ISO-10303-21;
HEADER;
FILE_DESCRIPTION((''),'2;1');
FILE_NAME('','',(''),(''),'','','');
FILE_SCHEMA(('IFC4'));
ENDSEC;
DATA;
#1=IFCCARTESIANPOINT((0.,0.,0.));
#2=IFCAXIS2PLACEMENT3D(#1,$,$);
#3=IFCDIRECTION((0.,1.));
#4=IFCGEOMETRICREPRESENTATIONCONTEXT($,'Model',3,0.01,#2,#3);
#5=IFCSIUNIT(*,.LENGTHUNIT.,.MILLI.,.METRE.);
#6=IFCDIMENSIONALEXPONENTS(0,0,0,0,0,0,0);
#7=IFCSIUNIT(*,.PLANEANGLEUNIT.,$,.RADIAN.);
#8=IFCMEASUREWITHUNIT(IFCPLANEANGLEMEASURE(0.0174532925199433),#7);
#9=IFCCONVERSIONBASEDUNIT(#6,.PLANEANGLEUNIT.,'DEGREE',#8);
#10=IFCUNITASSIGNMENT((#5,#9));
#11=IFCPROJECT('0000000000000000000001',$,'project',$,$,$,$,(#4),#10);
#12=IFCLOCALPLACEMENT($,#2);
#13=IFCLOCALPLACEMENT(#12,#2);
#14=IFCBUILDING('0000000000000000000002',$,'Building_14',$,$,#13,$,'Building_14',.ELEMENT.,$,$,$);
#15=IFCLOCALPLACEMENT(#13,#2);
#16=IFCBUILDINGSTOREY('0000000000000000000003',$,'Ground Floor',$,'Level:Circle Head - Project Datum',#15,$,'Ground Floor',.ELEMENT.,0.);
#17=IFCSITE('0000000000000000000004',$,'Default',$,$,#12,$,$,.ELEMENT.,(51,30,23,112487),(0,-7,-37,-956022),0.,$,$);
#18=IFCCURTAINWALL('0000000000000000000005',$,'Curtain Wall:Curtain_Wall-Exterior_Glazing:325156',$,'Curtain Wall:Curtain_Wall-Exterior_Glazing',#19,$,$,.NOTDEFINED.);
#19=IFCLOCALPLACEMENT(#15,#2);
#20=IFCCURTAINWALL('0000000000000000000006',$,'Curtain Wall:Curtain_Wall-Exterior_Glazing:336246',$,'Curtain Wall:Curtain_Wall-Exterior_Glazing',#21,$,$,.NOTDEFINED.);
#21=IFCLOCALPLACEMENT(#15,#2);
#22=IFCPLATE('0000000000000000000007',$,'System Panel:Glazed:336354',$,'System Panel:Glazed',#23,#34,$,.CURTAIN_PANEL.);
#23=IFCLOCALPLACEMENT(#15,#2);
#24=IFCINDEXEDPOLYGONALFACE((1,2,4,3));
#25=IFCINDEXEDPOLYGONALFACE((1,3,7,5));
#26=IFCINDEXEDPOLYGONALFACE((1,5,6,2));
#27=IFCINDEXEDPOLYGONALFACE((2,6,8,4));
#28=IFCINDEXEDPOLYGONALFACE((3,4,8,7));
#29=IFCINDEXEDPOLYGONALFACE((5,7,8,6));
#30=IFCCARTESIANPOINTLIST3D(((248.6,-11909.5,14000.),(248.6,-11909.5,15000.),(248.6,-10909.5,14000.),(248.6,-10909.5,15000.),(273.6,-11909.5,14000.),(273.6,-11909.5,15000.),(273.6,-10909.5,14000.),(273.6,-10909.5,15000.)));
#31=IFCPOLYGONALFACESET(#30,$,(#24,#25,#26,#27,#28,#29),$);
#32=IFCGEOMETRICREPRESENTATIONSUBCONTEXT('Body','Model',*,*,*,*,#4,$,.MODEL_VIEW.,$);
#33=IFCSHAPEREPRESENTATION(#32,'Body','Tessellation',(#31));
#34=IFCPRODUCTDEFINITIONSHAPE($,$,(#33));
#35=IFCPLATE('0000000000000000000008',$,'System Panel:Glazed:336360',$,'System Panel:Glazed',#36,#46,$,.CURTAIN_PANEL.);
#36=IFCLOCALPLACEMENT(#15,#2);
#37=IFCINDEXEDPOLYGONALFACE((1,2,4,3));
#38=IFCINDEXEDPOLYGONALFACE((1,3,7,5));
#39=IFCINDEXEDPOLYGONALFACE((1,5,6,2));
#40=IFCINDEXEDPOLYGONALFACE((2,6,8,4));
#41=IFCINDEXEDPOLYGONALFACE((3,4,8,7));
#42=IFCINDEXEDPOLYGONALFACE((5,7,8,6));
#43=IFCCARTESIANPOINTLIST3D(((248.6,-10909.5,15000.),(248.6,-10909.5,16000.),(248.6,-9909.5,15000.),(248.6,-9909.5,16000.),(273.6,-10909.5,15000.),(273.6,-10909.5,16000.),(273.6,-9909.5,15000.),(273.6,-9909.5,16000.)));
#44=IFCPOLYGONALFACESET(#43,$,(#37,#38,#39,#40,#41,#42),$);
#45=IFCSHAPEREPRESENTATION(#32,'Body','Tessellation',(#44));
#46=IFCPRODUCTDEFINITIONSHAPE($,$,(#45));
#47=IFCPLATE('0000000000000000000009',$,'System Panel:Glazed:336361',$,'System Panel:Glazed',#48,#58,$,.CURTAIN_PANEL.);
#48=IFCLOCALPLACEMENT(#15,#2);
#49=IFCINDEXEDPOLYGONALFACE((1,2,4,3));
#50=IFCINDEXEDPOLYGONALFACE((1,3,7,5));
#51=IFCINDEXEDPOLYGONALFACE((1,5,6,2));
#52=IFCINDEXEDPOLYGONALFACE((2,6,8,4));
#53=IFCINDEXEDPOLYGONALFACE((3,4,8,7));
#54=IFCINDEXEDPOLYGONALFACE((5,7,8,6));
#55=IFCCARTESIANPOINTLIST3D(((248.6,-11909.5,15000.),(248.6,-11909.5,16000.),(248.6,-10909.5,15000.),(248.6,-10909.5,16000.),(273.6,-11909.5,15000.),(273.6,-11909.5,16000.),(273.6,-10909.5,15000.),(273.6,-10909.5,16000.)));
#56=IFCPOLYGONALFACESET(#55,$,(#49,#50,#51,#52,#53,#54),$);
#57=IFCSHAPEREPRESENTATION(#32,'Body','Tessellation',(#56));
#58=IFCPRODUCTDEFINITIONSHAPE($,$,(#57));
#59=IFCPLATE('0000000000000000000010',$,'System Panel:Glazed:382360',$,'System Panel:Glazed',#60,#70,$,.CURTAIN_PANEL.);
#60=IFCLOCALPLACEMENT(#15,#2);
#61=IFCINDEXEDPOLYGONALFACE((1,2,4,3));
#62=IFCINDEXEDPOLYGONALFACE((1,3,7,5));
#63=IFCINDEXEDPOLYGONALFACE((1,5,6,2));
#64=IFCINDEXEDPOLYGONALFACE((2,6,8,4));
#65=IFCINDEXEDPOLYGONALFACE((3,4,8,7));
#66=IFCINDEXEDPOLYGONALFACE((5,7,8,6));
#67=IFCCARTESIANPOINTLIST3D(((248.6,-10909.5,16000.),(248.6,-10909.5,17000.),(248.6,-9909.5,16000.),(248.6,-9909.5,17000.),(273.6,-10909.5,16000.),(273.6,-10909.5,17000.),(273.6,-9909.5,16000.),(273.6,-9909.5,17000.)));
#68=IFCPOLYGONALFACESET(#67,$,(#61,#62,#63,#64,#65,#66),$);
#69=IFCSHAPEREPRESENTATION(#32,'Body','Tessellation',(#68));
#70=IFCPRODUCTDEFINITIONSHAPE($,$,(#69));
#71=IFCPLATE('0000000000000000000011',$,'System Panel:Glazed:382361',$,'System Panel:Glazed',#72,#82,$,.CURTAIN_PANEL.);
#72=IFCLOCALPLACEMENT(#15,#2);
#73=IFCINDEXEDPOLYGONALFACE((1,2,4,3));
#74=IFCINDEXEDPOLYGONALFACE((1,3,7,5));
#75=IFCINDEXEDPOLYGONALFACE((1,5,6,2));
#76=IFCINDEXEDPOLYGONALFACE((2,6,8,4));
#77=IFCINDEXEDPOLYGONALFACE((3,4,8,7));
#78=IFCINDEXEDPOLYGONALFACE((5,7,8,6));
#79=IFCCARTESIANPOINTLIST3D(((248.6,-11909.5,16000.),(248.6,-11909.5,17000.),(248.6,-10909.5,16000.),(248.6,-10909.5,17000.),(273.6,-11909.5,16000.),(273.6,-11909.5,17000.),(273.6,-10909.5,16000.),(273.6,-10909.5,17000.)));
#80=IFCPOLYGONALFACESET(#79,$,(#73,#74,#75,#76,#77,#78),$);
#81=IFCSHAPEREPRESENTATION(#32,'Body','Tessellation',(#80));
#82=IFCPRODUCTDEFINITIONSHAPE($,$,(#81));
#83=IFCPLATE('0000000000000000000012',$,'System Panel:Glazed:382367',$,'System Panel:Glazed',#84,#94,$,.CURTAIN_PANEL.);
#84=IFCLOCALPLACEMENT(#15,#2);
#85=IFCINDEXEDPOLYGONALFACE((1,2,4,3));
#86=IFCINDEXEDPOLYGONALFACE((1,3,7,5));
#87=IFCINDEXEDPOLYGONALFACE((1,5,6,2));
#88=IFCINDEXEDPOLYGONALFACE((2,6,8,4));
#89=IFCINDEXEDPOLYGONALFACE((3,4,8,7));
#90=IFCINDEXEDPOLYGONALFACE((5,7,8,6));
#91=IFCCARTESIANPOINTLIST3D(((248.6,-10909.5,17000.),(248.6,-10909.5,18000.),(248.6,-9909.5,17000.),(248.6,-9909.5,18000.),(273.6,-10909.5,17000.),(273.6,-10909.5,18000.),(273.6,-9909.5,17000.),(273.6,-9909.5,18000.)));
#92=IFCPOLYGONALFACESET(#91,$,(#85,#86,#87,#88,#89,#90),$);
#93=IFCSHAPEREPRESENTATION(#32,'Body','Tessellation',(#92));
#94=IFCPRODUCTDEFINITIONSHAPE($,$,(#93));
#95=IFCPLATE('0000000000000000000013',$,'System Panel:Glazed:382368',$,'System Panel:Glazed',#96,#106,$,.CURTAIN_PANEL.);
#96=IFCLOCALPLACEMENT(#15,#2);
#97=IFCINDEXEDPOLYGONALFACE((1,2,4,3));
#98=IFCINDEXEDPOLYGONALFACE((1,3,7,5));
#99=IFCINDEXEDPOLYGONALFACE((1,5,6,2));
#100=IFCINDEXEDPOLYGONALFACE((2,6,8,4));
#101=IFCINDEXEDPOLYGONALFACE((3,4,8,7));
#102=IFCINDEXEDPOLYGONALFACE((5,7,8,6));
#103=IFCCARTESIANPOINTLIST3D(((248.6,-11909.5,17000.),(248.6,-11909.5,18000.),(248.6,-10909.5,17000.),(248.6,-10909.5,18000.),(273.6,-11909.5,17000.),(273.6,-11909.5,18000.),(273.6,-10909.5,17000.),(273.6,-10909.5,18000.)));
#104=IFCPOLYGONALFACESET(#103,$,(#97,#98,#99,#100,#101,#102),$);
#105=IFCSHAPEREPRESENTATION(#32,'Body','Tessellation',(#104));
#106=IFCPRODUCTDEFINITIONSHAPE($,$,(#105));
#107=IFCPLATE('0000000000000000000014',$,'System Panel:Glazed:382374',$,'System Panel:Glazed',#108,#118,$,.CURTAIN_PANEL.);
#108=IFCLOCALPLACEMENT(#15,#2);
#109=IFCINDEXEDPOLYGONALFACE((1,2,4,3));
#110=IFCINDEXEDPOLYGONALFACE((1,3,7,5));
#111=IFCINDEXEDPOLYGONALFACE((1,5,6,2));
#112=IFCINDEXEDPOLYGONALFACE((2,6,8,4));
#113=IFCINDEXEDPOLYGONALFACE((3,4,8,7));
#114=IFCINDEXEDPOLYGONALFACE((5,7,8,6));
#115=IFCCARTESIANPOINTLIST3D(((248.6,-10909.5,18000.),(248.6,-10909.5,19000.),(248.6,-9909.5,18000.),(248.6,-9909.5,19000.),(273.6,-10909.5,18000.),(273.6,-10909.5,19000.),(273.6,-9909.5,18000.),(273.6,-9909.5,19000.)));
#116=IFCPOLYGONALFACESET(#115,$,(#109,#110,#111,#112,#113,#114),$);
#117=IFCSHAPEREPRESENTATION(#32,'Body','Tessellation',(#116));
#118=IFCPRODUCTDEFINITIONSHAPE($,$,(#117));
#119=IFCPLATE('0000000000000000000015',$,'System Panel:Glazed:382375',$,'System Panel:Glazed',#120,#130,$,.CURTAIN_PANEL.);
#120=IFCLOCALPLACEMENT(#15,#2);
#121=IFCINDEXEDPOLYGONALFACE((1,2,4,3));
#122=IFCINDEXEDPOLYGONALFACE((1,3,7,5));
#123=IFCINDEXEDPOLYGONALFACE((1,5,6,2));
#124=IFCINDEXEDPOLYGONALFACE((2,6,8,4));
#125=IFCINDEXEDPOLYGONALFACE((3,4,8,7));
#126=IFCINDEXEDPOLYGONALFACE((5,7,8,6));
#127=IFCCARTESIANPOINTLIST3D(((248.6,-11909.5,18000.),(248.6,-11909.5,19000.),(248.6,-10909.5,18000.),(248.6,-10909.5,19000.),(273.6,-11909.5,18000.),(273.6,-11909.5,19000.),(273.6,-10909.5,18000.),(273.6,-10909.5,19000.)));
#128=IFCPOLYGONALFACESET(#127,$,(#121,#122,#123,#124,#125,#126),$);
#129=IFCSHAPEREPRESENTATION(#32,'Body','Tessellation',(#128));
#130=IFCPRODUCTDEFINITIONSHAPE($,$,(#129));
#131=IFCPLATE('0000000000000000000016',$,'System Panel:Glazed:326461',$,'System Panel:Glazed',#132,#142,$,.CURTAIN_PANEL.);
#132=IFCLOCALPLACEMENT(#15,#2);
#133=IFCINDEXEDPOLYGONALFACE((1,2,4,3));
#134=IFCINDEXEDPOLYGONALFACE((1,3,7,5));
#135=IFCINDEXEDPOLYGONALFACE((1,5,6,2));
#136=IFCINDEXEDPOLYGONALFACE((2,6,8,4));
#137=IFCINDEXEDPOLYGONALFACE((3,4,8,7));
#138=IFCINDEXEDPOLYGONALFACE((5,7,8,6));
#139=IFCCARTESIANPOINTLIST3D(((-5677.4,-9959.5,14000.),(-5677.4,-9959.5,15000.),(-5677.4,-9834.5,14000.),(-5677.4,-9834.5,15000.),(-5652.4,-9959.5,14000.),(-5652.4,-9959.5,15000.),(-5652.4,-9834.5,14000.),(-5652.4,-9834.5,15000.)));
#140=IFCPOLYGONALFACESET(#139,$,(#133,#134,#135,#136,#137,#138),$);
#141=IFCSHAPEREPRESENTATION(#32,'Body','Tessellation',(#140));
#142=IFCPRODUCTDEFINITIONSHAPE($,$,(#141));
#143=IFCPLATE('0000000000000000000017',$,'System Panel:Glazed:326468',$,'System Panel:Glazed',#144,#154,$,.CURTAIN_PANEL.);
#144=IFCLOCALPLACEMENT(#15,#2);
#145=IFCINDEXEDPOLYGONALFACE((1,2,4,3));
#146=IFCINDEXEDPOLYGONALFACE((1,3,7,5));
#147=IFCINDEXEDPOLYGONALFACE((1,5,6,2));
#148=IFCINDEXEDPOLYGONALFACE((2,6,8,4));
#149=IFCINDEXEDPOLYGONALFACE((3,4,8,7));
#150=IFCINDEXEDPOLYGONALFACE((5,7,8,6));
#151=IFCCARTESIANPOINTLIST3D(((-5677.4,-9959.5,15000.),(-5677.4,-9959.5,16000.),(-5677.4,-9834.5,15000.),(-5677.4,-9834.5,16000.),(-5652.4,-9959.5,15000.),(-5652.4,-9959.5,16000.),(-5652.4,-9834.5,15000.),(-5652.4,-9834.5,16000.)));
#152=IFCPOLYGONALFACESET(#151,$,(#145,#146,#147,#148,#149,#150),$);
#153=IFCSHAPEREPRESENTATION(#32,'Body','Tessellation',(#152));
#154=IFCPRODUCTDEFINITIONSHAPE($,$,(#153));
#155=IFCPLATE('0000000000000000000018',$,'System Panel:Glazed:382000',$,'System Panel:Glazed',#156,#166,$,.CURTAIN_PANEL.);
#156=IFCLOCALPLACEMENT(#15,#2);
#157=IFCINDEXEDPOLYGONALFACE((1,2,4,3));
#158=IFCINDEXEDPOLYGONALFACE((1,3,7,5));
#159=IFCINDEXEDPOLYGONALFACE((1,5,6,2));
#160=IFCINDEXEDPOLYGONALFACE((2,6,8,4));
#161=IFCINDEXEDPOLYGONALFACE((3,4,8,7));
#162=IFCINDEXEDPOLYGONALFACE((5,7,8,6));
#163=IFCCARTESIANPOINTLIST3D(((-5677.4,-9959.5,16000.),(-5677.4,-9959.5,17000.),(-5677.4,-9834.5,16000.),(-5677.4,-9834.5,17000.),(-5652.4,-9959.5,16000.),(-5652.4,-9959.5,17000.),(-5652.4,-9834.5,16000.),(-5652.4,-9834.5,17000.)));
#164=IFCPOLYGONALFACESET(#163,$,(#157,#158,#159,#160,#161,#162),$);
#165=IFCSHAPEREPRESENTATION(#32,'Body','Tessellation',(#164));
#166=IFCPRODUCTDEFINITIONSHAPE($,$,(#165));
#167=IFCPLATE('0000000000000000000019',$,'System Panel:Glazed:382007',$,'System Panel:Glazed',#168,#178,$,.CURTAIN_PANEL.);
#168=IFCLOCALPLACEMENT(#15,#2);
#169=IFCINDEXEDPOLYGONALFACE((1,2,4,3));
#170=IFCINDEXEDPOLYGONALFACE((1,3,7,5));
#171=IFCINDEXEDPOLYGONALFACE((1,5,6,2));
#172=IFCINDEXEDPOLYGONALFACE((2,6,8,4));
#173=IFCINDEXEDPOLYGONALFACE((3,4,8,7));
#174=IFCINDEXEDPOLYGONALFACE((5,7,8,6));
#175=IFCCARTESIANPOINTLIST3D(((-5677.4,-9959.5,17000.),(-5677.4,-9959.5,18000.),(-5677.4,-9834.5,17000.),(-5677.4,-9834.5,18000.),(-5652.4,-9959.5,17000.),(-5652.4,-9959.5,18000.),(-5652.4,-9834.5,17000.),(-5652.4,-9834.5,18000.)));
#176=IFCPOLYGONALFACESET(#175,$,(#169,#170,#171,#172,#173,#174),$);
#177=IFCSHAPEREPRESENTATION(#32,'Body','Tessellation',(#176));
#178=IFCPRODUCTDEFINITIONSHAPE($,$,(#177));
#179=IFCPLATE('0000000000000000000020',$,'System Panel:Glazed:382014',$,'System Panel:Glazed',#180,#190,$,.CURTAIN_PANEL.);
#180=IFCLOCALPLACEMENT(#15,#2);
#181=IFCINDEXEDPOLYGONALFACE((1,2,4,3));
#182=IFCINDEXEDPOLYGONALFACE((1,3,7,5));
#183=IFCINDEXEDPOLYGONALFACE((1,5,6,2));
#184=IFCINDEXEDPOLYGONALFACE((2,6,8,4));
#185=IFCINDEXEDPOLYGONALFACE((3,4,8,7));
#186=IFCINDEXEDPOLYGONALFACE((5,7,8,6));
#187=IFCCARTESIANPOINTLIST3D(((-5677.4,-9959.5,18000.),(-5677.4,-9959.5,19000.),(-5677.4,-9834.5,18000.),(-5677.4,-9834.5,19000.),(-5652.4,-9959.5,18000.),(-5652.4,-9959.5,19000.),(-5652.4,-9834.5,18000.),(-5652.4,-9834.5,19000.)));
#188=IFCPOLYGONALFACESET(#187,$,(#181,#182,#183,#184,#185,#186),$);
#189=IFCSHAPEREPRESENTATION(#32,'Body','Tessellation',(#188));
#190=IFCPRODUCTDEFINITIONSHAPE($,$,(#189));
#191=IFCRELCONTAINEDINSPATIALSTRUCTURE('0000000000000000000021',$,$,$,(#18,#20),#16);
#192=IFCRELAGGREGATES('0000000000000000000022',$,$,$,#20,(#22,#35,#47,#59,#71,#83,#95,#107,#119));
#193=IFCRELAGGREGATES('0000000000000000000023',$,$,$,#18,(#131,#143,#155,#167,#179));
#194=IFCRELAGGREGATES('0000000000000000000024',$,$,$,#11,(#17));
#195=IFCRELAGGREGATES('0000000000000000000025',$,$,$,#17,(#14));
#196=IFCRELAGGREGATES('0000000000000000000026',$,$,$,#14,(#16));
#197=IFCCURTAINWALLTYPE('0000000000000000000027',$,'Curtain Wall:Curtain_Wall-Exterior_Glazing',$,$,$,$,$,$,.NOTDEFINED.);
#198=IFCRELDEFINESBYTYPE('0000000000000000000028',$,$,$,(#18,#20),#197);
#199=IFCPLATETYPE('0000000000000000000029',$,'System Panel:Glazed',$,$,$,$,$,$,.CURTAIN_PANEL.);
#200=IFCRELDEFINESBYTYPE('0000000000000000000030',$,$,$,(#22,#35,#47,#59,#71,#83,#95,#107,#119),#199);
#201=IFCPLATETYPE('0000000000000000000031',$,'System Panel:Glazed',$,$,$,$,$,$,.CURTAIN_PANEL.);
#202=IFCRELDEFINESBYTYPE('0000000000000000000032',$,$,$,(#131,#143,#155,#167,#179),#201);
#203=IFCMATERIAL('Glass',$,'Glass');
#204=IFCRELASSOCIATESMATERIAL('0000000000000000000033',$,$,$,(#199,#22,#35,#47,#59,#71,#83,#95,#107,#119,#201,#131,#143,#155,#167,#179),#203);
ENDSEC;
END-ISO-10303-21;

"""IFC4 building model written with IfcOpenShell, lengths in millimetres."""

from ifc_helpers import new_model, entity, si_unit, converted_unit, direction, frame, origin, place, context, subcontext, project, spatial, indexed_curve, outline, extrude, source, transform, mapped, material, type_object, type_shapes, element, aggregate, save


model = new_model("IFC4")

# Units and contexts
model_context = context("Model", 3, precision=0.01, world=origin(), true_north=direction((0.0, 1.0)))
body_context = subcontext(model_context, "Body", "Model", "MODEL_VIEW")
ifc_project = project(units=[si_unit("LENGTHUNIT", "METRE", prefix="MILLI"), converted_unit("PLANEANGLEUNIT", "DEGREE", entity("IfcPlaneAngleMeasure", 0.0174532925199433), si_unit("PLANEANGLEUNIT", "RADIAN"), dimensions=[0, 0, 0, 0, 0, 0, 0])], contexts=[model_context])

# Site, building, storey
site_placement = place(None, origin())
site = spatial("IfcSite", under=ifc_project, at=site_placement, Name="Default", CompositionType="ELEMENT", RefLatitude=(51, 30, 23, 112487), RefLongitude=(0, -7, -37, -956022), RefElevation=0.0)
building_placement = place(site_placement, origin())
building = spatial("IfcBuilding", under=site, at=building_placement, Name="Building_14", LongName="Building_14", CompositionType="ELEMENT")
storey_placement = place(building_placement, origin())
storey = spatial("IfcBuildingStorey", under=building, at=storey_placement, Name="Ground Floor", ObjectType="Level:Circle Head - Project Datum", LongName="Ground Floor", CompositionType="ELEMENT", Elevation=0.0)

# Curtain walls, plates
curtain_wall_type = type_object("IfcCurtainWallType", Name="Curtain Wall:Curtain_Wall-Exterior_Glazing", PredefinedType="NOTDEFINED")
curtain_wall_1_placement = place(storey_placement, origin())
curtain_wall_1 = element("IfcCurtainWall", 1, at=curtain_wall_1_placement, inside=storey, type_object=curtain_wall_type, Name="Curtain Wall:Curtain_Wall-Exterior_Glazing:325156", ObjectType="Curtain Wall:Curtain_Wall-Exterior_Glazing", PredefinedType="NOTDEFINED")
ifc_material = material(Name="Glass", Category="Glass")
plate_type_1 = type_object("IfcPlateType", Name="System Panel:Glazed", PredefinedType="CURTAIN_PANEL", material=ifc_material)
shared_shape_1 = source(origin(), body_context, "Body", "SweptSolid", [
    extrude(outline(indexed_curve([(-12.5, -500.0), (12.5, -500.0), (12.5, 500.0), (-12.5, 500.0), (-12.5, -500.0)], self_intersect=False)), frame((0.0, -37.0, 0.0), z_axis=(0.0, 0.0, 1.0), x_axis=(0.0, 1.0, 0.0)), (0.0, 0.0, 1.0), 1000.0),
])
type_shapes(plate_type_1, [shared_shape_1])
curtain_wall_2_placement = place(storey_placement, origin())
curtain_wall_2 = element("IfcCurtainWall", 2, at=curtain_wall_2_placement, inside=storey, type_object=curtain_wall_type, Name="Curtain Wall:Curtain_Wall-Exterior_Glazing:336246", ObjectType="Curtain Wall:Curtain_Wall-Exterior_Glazing", PredefinedType="NOTDEFINED")
plate_1_placement = place(curtain_wall_2_placement, frame((298.1, -11409.5, 14000.0), z_axis=(0.0, 0.0, 1.0), x_axis=(0.0, -1.0, 0.0)))
plate_1 = element("IfcPlate", 3, at=plate_1_placement, type_object=plate_type_1, material=ifc_material, Name="System Panel:Glazed:336354", ObjectType="System Panel:Glazed", PredefinedType="CURTAIN_PANEL", context=body_context, shape_type="MappedRepresentation", body=[
    mapped(shared_shape_1, transform((0.0, 0.0, 0.0), scale=1.0)),
])
plate_2_placement = place(curtain_wall_2_placement, frame((298.1, -10409.5, 15000.0), z_axis=(0.0, 0.0, 1.0), x_axis=(0.0, -1.0, 0.0)))
plate_2 = element("IfcPlate", 4, at=plate_2_placement, type_object=plate_type_1, material=ifc_material, Name="System Panel:Glazed:336360", ObjectType="System Panel:Glazed", PredefinedType="CURTAIN_PANEL", context=body_context, shape_type="MappedRepresentation", body=[
    mapped(shared_shape_1, transform((0.0, 0.0, 0.0), scale=1.0)),
])
plate_3_placement = place(curtain_wall_2_placement, frame((298.1, -11409.5, 15000.0), z_axis=(0.0, 0.0, 1.0), x_axis=(0.0, -1.0, 0.0)))
plate_3 = element("IfcPlate", 5, at=plate_3_placement, type_object=plate_type_1, material=ifc_material, Name="System Panel:Glazed:336361", ObjectType="System Panel:Glazed", PredefinedType="CURTAIN_PANEL", context=body_context, shape_type="MappedRepresentation", body=[
    mapped(shared_shape_1, transform((0.0, 0.0, 0.0), scale=1.0)),
])
plate_4_placement = place(curtain_wall_2_placement, frame((298.1, -10409.5, 16000.0), z_axis=(0.0, 0.0, 1.0), x_axis=(0.0, -1.0, 0.0)))
plate_4 = element("IfcPlate", 6, at=plate_4_placement, type_object=plate_type_1, material=ifc_material, Name="System Panel:Glazed:382360", ObjectType="System Panel:Glazed", PredefinedType="CURTAIN_PANEL", context=body_context, shape_type="MappedRepresentation", body=[
    mapped(shared_shape_1, transform((0.0, 0.0, 0.0), scale=1.0)),
])
plate_5_placement = place(curtain_wall_2_placement, frame((298.1, -11409.5, 16000.0), z_axis=(0.0, 0.0, 1.0), x_axis=(0.0, -1.0, 0.0)))
plate_5 = element("IfcPlate", 7, at=plate_5_placement, type_object=plate_type_1, material=ifc_material, Name="System Panel:Glazed:382361", ObjectType="System Panel:Glazed", PredefinedType="CURTAIN_PANEL", context=body_context, shape_type="MappedRepresentation", body=[
    mapped(shared_shape_1, transform((0.0, 0.0, 0.0), scale=1.0)),
])
plate_6_placement = place(curtain_wall_2_placement, frame((298.1, -10409.5, 17000.0), z_axis=(0.0, 0.0, 1.0), x_axis=(0.0, -1.0, 0.0)))
plate_6 = element("IfcPlate", 8, at=plate_6_placement, type_object=plate_type_1, material=ifc_material, Name="System Panel:Glazed:382367", ObjectType="System Panel:Glazed", PredefinedType="CURTAIN_PANEL", context=body_context, shape_type="MappedRepresentation", body=[
    mapped(shared_shape_1, transform((0.0, 0.0, 0.0), scale=1.0)),
])
plate_7_placement = place(curtain_wall_2_placement, frame((298.1, -11409.5, 17000.0), z_axis=(0.0, 0.0, 1.0), x_axis=(0.0, -1.0, 0.0)))
plate_7 = element("IfcPlate", 9, at=plate_7_placement, type_object=plate_type_1, material=ifc_material, Name="System Panel:Glazed:382368", ObjectType="System Panel:Glazed", PredefinedType="CURTAIN_PANEL", context=body_context, shape_type="MappedRepresentation", body=[
    mapped(shared_shape_1, transform((0.0, 0.0, 0.0), scale=1.0)),
])
plate_8_placement = place(curtain_wall_2_placement, frame((298.1, -10409.5, 18000.0), z_axis=(0.0, 0.0, 1.0), x_axis=(0.0, -1.0, 0.0)))
plate_8 = element("IfcPlate", 10, at=plate_8_placement, type_object=plate_type_1, material=ifc_material, Name="System Panel:Glazed:382374", ObjectType="System Panel:Glazed", PredefinedType="CURTAIN_PANEL", context=body_context, shape_type="MappedRepresentation", body=[
    mapped(shared_shape_1, transform((0.0, 0.0, 0.0), scale=1.0)),
])
plate_9_placement = place(curtain_wall_2_placement, frame((298.1, -11409.5, 18000.0), z_axis=(0.0, 0.0, 1.0), x_axis=(0.0, -1.0, 0.0)))
plate_9 = element("IfcPlate", 11, at=plate_9_placement, type_object=plate_type_1, material=ifc_material, Name="System Panel:Glazed:382375", ObjectType="System Panel:Glazed", PredefinedType="CURTAIN_PANEL", context=body_context, shape_type="MappedRepresentation", body=[
    mapped(shared_shape_1, transform((0.0, 0.0, 0.0), scale=1.0)),
])
aggregate(curtain_wall_2, [plate_1, plate_2, plate_3, plate_4, plate_5, plate_6, plate_7, plate_8, plate_9])

# Plates
plate_type_2 = type_object("IfcPlateType", Name="System Panel:Glazed", PredefinedType="CURTAIN_PANEL", material=ifc_material)
shared_shape_2 = source(origin(), body_context, "Body", "SweptSolid", [
    extrude(outline(indexed_curve([(-12.5, -62.5), (12.5, -62.5), (12.5, 62.5), (-12.5, 62.5), (-12.5, -62.5)], self_intersect=False)), frame((0.0, -37.0, 0.0), z_axis=(0.0, 0.0, 1.0), x_axis=(0.0, 1.0, 0.0)), (0.0, 0.0, 1.0), 1000.0),
])
type_shapes(plate_type_2, [shared_shape_2])
plate_10_placement = place(curtain_wall_1_placement, frame((-5701.9, -9897.0, 14000.0), z_axis=(0.0, 0.0, 1.0), x_axis=(0.0, 1.0, 0.0)))
plate_10 = element("IfcPlate", 12, at=plate_10_placement, type_object=plate_type_2, material=ifc_material, Name="System Panel:Glazed:326461", ObjectType="System Panel:Glazed", PredefinedType="CURTAIN_PANEL", context=body_context, shape_type="MappedRepresentation", body=[
    mapped(shared_shape_2, transform((0.0, 0.0, 0.0), scale=1.0)),
])
plate_11_placement = place(curtain_wall_1_placement, frame((-5701.9, -9897.0, 15000.0), z_axis=(0.0, 0.0, 1.0), x_axis=(0.0, 1.0, 0.0)))
plate_11 = element("IfcPlate", 13, at=plate_11_placement, type_object=plate_type_2, material=ifc_material, Name="System Panel:Glazed:326468", ObjectType="System Panel:Glazed", PredefinedType="CURTAIN_PANEL", context=body_context, shape_type="MappedRepresentation", body=[
    mapped(shared_shape_2, transform((0.0, 0.0, 0.0), scale=1.0)),
])
plate_12_placement = place(curtain_wall_1_placement, frame((-5701.9, -9897.0, 16000.0), z_axis=(0.0, 0.0, 1.0), x_axis=(0.0, 1.0, 0.0)))
plate_12 = element("IfcPlate", 14, at=plate_12_placement, type_object=plate_type_2, material=ifc_material, Name="System Panel:Glazed:382000", ObjectType="System Panel:Glazed", PredefinedType="CURTAIN_PANEL", context=body_context, shape_type="MappedRepresentation", body=[
    mapped(shared_shape_2, transform((0.0, 0.0, 0.0), scale=1.0)),
])
plate_13_placement = place(curtain_wall_1_placement, frame((-5701.9, -9897.0, 17000.0), z_axis=(0.0, 0.0, 1.0), x_axis=(0.0, 1.0, 0.0)))
plate_13 = element("IfcPlate", 15, at=plate_13_placement, type_object=plate_type_2, material=ifc_material, Name="System Panel:Glazed:382007", ObjectType="System Panel:Glazed", PredefinedType="CURTAIN_PANEL", context=body_context, shape_type="MappedRepresentation", body=[
    mapped(shared_shape_2, transform((0.0, 0.0, 0.0), scale=1.0)),
])
plate_14_placement = place(curtain_wall_1_placement, frame((-5701.9, -9897.0, 18000.0), z_axis=(0.0, 0.0, 1.0), x_axis=(0.0, 1.0, 0.0)))
plate_14 = element("IfcPlate", 16, at=plate_14_placement, type_object=plate_type_2, material=ifc_material, Name="System Panel:Glazed:382014", ObjectType="System Panel:Glazed", PredefinedType="CURTAIN_PANEL", context=body_context, shape_type="MappedRepresentation", body=[
    mapped(shared_shape_2, transform((0.0, 0.0, 0.0), scale=1.0)),
])
aggregate(curtain_wall_1, [plate_10, plate_11, plate_12, plate_13, plate_14])

save(model, "model.ifc")
